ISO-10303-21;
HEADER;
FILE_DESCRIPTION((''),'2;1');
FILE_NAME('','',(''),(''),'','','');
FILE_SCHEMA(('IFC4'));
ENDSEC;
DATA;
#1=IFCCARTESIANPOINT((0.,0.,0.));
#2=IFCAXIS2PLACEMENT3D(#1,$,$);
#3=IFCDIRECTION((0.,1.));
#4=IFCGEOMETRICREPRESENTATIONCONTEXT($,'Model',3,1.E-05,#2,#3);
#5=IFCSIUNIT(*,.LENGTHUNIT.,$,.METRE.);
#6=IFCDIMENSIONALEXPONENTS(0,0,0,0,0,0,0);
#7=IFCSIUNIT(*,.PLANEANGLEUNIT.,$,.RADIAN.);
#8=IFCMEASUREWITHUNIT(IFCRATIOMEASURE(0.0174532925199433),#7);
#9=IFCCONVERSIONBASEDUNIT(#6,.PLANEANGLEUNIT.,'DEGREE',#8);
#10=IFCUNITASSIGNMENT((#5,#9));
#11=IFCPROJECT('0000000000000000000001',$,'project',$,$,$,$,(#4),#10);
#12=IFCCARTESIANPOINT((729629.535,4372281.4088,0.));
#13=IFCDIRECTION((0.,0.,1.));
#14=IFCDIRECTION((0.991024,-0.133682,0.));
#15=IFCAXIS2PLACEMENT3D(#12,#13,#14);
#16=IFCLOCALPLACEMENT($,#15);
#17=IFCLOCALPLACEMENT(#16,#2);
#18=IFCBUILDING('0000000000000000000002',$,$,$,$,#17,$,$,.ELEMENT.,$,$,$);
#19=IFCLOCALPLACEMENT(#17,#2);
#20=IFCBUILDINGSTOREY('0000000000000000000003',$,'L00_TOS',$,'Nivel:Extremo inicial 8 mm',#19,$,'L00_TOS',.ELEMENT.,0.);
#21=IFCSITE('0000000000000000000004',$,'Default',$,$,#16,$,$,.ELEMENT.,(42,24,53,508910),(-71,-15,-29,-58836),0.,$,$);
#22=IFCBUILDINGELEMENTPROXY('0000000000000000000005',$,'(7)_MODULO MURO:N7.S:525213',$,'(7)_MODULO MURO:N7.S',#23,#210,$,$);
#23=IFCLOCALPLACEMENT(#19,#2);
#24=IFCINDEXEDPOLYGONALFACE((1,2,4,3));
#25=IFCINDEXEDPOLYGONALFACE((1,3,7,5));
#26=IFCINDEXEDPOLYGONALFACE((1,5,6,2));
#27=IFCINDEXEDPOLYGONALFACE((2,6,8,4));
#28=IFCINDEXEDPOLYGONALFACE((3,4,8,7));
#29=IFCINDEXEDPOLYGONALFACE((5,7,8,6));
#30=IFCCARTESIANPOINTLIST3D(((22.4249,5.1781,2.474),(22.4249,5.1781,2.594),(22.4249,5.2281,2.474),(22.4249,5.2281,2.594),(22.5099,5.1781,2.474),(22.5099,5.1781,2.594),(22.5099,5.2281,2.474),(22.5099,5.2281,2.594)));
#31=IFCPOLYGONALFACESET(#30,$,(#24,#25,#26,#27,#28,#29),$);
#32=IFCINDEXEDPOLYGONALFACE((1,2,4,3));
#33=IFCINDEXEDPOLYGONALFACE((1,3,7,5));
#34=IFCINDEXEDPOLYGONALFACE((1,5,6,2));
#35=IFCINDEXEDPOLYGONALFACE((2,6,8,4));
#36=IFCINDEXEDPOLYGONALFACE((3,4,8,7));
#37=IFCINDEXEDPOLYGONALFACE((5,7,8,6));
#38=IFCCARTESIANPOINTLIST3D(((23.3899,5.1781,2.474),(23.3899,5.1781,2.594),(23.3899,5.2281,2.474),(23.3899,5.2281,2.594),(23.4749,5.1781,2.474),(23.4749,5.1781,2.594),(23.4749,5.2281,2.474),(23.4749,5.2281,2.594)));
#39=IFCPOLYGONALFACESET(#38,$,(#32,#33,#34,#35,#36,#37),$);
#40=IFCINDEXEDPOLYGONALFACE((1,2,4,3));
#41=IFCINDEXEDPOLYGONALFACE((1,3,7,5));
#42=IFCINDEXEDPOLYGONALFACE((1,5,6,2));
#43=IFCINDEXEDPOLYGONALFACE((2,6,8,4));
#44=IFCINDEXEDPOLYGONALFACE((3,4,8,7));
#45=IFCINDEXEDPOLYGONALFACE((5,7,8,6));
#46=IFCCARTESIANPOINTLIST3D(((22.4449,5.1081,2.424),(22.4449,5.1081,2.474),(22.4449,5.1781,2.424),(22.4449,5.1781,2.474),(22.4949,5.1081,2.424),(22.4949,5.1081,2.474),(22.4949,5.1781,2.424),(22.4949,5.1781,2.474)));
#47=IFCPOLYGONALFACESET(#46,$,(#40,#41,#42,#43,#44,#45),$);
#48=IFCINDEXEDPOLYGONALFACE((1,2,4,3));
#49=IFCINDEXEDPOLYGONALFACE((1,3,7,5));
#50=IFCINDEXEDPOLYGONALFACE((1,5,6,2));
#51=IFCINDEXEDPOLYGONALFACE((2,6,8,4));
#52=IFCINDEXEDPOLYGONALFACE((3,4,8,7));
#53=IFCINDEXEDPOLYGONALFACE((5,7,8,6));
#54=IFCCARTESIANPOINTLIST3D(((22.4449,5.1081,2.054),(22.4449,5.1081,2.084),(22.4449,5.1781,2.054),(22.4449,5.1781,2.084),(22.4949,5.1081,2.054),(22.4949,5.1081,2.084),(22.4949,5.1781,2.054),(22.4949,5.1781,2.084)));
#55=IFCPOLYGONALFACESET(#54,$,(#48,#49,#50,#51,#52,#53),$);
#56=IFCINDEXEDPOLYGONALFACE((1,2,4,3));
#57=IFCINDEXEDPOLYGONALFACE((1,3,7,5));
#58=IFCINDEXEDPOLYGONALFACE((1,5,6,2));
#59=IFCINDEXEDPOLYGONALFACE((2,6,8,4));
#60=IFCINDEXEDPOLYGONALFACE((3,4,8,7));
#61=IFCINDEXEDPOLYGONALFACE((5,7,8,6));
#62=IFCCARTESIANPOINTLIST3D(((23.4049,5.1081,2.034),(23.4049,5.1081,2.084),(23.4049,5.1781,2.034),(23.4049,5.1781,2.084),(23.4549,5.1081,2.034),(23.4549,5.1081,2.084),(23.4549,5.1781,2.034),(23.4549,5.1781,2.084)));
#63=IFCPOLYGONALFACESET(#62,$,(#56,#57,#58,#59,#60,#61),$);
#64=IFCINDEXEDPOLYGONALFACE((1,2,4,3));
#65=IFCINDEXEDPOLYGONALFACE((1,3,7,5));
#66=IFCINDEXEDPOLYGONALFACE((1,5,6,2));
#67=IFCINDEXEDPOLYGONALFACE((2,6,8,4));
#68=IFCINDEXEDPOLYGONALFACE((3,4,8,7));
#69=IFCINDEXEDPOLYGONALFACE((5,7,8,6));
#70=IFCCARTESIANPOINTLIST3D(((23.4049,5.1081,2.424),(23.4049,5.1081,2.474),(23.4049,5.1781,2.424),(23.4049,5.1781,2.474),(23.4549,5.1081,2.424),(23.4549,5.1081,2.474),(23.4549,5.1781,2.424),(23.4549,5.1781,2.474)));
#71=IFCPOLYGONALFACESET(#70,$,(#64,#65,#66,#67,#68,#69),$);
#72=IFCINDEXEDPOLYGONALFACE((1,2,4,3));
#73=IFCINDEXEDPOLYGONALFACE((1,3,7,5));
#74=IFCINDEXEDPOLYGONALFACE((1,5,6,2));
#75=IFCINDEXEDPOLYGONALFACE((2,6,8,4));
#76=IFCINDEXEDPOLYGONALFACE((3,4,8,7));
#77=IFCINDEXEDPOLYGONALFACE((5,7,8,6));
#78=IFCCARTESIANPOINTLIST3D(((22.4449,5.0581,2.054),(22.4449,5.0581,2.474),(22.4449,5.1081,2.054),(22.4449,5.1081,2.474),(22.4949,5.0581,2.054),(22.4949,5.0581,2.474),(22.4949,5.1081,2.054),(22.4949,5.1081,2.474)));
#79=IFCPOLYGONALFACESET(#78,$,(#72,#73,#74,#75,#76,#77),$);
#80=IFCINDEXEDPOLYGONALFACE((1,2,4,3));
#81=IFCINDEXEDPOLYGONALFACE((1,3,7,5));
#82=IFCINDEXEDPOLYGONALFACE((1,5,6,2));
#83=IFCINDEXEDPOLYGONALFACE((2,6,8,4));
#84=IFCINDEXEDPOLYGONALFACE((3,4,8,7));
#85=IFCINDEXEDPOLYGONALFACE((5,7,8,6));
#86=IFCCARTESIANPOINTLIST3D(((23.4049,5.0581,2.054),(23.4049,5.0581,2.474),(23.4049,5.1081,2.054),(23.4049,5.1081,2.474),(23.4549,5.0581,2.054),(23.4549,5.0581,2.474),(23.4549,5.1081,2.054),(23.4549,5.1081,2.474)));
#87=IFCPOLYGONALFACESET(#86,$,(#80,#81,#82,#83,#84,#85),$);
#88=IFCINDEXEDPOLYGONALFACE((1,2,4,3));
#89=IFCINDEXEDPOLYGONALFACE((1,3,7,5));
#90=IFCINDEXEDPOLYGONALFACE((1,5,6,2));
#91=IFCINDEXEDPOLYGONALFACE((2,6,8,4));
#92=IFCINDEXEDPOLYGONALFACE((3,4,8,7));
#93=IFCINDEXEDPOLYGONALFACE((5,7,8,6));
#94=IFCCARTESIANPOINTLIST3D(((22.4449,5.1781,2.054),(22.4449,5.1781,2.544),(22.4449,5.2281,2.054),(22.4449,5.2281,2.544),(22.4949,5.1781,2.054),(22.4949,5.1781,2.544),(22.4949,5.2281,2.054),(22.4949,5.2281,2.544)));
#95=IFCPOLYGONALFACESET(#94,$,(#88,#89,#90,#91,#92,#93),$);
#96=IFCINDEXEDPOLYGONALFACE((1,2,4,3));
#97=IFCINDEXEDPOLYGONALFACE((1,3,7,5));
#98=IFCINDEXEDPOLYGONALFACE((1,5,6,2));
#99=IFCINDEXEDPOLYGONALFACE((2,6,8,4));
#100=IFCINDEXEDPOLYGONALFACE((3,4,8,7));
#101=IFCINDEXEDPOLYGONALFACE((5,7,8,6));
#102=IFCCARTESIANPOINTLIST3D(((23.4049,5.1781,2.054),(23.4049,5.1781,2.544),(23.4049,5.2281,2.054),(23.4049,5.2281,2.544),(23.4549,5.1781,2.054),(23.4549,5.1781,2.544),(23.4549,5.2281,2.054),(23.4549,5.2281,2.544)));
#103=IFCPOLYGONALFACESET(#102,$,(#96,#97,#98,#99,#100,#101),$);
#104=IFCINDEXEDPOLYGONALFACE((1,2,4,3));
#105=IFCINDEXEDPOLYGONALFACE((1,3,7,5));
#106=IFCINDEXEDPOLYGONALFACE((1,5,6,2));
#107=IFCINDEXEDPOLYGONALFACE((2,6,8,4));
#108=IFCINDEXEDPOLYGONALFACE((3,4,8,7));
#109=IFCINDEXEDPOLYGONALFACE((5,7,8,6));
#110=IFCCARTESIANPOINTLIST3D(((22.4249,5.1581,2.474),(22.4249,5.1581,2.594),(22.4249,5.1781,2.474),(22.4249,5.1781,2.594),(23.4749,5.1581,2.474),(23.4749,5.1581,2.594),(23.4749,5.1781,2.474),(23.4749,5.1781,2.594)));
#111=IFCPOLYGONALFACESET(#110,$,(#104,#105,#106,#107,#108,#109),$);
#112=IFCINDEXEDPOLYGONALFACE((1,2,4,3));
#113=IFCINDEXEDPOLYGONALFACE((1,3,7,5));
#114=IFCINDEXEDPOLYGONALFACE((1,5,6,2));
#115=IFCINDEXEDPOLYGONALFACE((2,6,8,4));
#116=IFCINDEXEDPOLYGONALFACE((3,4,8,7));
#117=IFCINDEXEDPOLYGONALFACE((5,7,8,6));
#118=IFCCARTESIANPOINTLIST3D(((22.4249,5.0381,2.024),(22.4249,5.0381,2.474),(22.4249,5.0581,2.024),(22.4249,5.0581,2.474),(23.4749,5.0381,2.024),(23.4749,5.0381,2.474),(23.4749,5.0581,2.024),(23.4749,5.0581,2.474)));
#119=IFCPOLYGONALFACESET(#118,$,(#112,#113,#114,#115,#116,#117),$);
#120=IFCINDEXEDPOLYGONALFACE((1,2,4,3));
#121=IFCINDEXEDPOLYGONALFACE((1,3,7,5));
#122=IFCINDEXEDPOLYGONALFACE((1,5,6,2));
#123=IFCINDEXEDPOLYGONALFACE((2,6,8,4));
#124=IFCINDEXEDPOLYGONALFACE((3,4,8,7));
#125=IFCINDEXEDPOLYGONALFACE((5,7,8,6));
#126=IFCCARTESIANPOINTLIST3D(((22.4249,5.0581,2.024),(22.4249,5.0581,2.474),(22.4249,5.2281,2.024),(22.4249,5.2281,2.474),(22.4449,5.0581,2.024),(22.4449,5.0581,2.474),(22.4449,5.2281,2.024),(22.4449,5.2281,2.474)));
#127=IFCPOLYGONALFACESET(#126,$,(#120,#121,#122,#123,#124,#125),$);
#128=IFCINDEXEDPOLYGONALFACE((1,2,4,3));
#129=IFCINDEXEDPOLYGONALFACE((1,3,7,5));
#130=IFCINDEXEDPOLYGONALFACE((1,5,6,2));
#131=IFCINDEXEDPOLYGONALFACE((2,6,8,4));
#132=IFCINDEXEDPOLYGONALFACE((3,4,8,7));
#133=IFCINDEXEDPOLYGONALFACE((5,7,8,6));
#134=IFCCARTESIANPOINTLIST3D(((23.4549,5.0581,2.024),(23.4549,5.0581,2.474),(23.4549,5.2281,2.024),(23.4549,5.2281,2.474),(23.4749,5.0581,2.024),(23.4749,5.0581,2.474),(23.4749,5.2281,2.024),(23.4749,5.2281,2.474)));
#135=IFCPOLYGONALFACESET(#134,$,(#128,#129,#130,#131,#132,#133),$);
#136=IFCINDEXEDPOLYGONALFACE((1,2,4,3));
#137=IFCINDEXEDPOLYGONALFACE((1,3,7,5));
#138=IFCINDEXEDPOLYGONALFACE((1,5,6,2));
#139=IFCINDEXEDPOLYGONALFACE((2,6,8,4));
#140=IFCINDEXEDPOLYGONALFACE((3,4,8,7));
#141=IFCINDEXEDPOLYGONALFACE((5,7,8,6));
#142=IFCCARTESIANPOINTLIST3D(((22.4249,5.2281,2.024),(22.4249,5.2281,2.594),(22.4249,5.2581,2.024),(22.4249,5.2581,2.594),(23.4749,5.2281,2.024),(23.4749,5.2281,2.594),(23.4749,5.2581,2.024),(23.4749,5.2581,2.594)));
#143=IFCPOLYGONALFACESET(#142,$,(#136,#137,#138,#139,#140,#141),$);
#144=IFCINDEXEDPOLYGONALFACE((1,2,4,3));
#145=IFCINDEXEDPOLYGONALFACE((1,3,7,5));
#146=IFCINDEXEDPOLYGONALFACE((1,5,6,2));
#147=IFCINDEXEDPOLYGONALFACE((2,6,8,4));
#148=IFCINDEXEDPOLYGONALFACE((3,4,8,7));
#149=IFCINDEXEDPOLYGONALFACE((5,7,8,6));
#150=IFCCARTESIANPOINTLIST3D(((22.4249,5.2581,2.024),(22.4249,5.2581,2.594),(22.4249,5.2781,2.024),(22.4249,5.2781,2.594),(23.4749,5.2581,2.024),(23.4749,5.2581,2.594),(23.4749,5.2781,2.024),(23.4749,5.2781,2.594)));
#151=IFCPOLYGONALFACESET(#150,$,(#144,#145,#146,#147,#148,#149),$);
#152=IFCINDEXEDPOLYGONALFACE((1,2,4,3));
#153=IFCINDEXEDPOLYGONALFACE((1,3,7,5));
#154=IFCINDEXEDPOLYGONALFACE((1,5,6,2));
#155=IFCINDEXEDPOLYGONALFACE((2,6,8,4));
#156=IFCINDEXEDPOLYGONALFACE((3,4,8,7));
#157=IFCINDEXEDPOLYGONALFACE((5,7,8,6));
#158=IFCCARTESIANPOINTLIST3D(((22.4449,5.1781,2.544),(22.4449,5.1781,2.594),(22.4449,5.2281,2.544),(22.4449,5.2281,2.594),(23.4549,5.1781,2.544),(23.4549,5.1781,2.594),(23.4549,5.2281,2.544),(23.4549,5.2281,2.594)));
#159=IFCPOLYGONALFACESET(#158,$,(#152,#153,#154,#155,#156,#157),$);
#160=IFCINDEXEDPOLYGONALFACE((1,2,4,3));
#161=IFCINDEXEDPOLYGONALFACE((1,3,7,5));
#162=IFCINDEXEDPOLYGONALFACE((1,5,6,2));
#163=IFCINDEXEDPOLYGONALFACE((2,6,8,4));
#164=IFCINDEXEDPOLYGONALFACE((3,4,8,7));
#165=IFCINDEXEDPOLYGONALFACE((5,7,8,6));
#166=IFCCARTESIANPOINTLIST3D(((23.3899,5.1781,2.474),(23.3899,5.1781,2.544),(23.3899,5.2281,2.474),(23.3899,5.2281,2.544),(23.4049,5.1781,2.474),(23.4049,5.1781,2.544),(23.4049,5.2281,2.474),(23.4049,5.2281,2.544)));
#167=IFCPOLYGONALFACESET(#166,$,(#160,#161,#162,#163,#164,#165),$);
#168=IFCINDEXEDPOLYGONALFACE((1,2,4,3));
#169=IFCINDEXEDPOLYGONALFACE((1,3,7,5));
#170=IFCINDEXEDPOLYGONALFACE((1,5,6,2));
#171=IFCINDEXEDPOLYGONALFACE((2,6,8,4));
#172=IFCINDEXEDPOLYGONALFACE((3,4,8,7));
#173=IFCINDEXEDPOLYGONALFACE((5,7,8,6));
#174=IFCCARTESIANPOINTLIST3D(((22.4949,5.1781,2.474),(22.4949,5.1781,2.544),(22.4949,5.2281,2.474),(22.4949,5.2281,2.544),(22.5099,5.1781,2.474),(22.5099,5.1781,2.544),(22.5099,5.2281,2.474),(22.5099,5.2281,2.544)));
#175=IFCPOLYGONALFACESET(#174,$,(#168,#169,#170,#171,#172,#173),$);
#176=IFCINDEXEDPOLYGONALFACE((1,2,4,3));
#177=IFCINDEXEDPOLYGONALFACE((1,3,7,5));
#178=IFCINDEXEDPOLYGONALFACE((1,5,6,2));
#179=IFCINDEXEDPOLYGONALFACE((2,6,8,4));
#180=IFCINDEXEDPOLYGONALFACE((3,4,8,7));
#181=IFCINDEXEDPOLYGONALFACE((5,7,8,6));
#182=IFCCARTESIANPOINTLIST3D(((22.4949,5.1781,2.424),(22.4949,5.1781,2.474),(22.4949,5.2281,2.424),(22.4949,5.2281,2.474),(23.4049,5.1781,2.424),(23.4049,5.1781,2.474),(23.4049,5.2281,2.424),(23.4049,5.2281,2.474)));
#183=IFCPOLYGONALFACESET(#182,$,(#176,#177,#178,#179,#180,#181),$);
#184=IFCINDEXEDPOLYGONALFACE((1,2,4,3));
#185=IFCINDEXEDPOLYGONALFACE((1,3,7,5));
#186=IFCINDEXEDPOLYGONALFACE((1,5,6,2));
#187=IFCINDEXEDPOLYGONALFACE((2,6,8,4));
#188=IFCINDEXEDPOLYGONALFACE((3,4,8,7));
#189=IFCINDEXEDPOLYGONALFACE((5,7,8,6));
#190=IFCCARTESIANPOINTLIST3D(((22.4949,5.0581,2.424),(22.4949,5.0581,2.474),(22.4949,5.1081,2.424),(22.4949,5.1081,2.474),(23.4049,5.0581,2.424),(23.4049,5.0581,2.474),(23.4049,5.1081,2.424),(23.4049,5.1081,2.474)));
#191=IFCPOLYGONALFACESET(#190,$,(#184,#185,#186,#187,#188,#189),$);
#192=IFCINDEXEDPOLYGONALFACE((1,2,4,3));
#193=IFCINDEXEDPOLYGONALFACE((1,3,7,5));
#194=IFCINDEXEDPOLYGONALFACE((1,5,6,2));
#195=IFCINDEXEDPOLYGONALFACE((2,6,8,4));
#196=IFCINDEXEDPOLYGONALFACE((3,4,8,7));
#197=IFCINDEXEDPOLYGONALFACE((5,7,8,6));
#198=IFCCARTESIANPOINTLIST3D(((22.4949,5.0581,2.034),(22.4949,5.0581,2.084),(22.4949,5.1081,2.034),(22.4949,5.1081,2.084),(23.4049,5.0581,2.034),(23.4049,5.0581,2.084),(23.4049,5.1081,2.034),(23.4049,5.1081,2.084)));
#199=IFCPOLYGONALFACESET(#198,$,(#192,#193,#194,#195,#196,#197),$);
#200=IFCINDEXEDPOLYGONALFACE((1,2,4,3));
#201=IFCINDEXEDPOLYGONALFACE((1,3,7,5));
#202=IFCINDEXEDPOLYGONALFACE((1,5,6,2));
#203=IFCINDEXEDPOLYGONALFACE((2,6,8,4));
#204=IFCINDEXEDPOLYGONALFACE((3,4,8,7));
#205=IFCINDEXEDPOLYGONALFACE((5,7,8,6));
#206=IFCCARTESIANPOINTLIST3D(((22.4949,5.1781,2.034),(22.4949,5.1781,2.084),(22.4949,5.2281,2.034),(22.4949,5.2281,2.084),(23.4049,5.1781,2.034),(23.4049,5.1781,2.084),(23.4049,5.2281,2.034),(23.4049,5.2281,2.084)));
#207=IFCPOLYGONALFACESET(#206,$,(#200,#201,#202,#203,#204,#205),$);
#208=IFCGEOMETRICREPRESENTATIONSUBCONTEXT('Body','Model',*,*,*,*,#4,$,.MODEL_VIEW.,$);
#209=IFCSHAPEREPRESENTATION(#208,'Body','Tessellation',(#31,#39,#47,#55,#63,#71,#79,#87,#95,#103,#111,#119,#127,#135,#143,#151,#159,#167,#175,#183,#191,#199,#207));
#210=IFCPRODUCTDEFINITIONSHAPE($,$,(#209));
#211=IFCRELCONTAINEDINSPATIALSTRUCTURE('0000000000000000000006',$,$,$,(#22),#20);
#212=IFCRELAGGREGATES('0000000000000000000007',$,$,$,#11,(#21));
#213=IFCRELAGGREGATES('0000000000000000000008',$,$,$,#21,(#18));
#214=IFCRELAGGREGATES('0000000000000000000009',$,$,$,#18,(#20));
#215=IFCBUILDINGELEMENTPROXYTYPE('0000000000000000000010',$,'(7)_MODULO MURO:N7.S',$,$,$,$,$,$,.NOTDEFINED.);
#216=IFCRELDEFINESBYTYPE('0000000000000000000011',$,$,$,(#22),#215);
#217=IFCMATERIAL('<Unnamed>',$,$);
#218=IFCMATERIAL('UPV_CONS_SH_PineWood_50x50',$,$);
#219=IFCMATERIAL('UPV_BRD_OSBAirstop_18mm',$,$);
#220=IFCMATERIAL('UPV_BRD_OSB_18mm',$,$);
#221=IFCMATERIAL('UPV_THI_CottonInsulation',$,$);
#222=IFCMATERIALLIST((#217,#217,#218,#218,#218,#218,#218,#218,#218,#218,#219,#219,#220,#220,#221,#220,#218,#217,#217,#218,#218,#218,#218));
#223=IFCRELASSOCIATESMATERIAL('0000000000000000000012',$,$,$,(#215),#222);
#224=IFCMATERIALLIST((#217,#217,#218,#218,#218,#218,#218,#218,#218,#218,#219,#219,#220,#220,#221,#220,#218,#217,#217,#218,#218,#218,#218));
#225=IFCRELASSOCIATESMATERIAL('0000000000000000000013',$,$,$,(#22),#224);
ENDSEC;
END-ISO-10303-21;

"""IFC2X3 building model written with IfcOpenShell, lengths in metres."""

from ifc_helpers import new_model, entity, si_unit, converted_unit, direction, frame, frame_2d, origin, origin_2d_with_axis, place, context, subcontext, project, spatial, rectangle, extrude, source, transform, mapped, material, material_list, type_object, type_shapes, element, save


model = new_model("IFC2X3")

# Units and contexts
model_context = context("Model", 3, precision=1e-05, world=origin(), true_north=direction((0.0, 1.0)))
body_context = subcontext(model_context, "Body", "Model", "MODEL_VIEW")
ifc_project = project(units=[si_unit("LENGTHUNIT", "METRE"), converted_unit("PLANEANGLEUNIT", "DEGREE", entity("IfcRatioMeasure", 0.0174532925199433), si_unit("PLANEANGLEUNIT", "RADIAN"), dimensions=[0, 0, 0, 0, 0, 0, 0])], contexts=[model_context])

# Site, building, storey
site_placement = place(None, frame((729629.535, 4372281.4088, 0.0), z_axis=(0.0, 0.0, 1.0), x_axis=(0.991024, -0.133682, 0.0)))
site = spatial("IfcSite", under=ifc_project, at=site_placement, Name="Default", CompositionType="ELEMENT", RefLatitude=(42, 24, 53, 508910), RefLongitude=(-71, -15, -29, -58836), RefElevation=0.0)
building_placement = place(site_placement, origin())
building = spatial("IfcBuilding", under=site, at=building_placement, CompositionType="ELEMENT")
storey_placement = place(building_placement, origin())
storey = spatial("IfcBuildingStorey", under=building, at=storey_placement, Name="L00_TOS", ObjectType="Nivel:Extremo inicial 8 mm", LongName="L00_TOS", CompositionType="ELEMENT", Elevation=0.0)

# Building element proxy
ifc_material_1 = material(Name="UPV_BRD_OSBAirstop_18mm")
ifc_material_2 = material(Name="UPV_BRD_OSB_18mm")
ifc_material_3 = material(Name="UPV_THI_CottonInsulation")
ifc_material_4 = material(Name="<Unnamed>")
ifc_material_5 = material(Name="UPV_CONS_SH_PineWood_50x50")
ifc_material_list_1 = material_list([ifc_material_4, ifc_material_4, ifc_material_5, ifc_material_5, ifc_material_5, ifc_material_5, ifc_material_5, ifc_material_5, ifc_material_5, ifc_material_5, ifc_material_1, ifc_material_1, ifc_material_2, ifc_material_2, ifc_material_3, ifc_material_2, ifc_material_5, ifc_material_4, ifc_material_4, ifc_material_5, ifc_material_5, ifc_material_5, ifc_material_5])
ifc_material_list_2 = material_list([ifc_material_4, ifc_material_4, ifc_material_5, ifc_material_5, ifc_material_5, ifc_material_5, ifc_material_5, ifc_material_5, ifc_material_5, ifc_material_5, ifc_material_1, ifc_material_1, ifc_material_2, ifc_material_2, ifc_material_3, ifc_material_2, ifc_material_5, ifc_material_4, ifc_material_4, ifc_material_5, ifc_material_5, ifc_material_5, ifc_material_5])
building_element_proxy_type_1 = type_object("IfcBuildingElementProxyType", Name="(7)_MODULO MURO:N7.S", PredefinedType="NOTDEFINED", material=ifc_material_list_2)
shared_shape_1 = source(origin(), body_context, "Body", "SweptSolid", [
    extrude(rectangle(XDim=0.085, YDim=0.05, at=frame_2d((0.0, 0.0), x_axis=(1.0, 0.0))), frame((-0.4825, 0.025, 2.05), z_axis=(0.0, 0.0, 1.0), x_axis=(-1.0, 0.0, 0.0)), (0.0, 0.0, 1.0), 0.12),
    extrude(rectangle(XDim=0.085, YDim=0.05, at=frame_2d((0.0, 0.0), x_axis=(1.0, 0.0))), frame((0.4825, 0.025, 2.05), z_axis=(0.0, 0.0, 1.0), x_axis=(-1.0, 0.0, 0.0)), (0.0, 0.0, 1.0), 0.12),
    extrude(rectangle(XDim=0.07, YDim=0.05, at=frame_2d((0.0, 0.0), x_axis=(1.0, 0.0))), frame((-0.48, -0.035, 2.0), z_axis=(0.0, 0.0, 1.0), x_axis=(0.0, 1.0, 0.0)), (0.0, 0.0, 1.0), 0.05),
    extrude(rectangle(XDim=0.07, YDim=0.05, at=frame_2d((0.0, 0.0), x_axis=(1.0, 0.0))), frame((-0.48, -0.035, 1.63), z_axis=(0.0, 0.0, 1.0), x_axis=(0.0, 1.0, 0.0)), (0.0, 0.0, 1.0), 0.03),
    extrude(rectangle(XDim=0.07, YDim=0.05, at=frame_2d((0.0, 0.0), x_axis=(1.0, 0.0))), frame((0.48, -0.035, 1.61), z_axis=(0.0, 0.0, 1.0), x_axis=(0.0, 1.0, 0.0)), (0.0, 0.0, 1.0), 0.05),
    extrude(rectangle(XDim=0.07, YDim=0.05, at=frame_2d((0.0, 0.0), x_axis=(1.0, 0.0))), frame((0.48, -0.035, 2.0), z_axis=(0.0, 0.0, 1.0), x_axis=(0.0, 1.0, 0.0)), (0.0, 0.0, 1.0), 0.05),
    extrude(rectangle(XDim=0.05, YDim=0.05, at=frame_2d((0.0, 0.0), x_axis=(1.0, 0.0))), frame((-0.48, -0.095, 1.63), z_axis=(0.0, 0.0, 1.0), x_axis=(0.0, -1.0, 0.0)), (0.0, 0.0, 1.0), 0.42),
    extrude(rectangle(XDim=0.05, YDim=0.05, at=frame_2d((0.0, 0.0), x_axis=(1.0, 0.0))), frame((0.48, -0.095, 1.63), z_axis=(0.0, 0.0, 1.0), x_axis=(0.0, -1.0, 0.0)), (0.0, 0.0, 1.0), 0.42),
    extrude(rectangle(XDim=0.05, YDim=0.05, at=origin_2d_with_axis()), frame((-0.48, 0.025, 1.63), z_axis=(0.0, 0.0, 1.0), x_axis=(0.0, -1.0, 0.0)), (0.0, 0.0, 1.0), 0.49),
    extrude(rectangle(XDim=0.05, YDim=0.05, at=origin_2d_with_axis()), frame((0.48, 0.025, 1.63), z_axis=(0.0, 0.0, 1.0), x_axis=(0.0, -1.0, 0.0)), (0.0, 0.0, 1.0), 0.49),
    extrude(rectangle(XDim=1.05, YDim=0.02, at=origin_2d_with_axis()), frame((0.0, -0.01, 2.05), z_axis=(0.0, 0.0, 1.0), x_axis=(-1.0, 0.0, 0.0)), (0.0, 0.0, 1.0), 0.12),
    extrude(rectangle(XDim=1.05, YDim=0.02, at=origin_2d_with_axis()), frame((0.0, -0.13, 1.6)), (0.0, 0.0, 1.0), 0.45),
    extrude(rectangle(XDim=0.17, YDim=0.02, at=origin_2d_with_axis()), frame((-0.515, -0.035, 1.6), z_axis=(0.0, 0.0, 1.0), x_axis=(0.0, -1.0, 0.0)), (0.0, 0.0, 1.0), 0.45),
    extrude(rectangle(XDim=0.17, YDim=0.02, at=frame_2d((0.0, 0.0), x_axis=(1.0, 0.0))), frame((0.515, -0.035, 1.6), z_axis=(0.0, 0.0, 1.0), x_axis=(0.0, -1.0, 0.0)), (0.0, 0.0, 1.0), 0.45),
    extrude(rectangle(XDim=0.03, YDim=1.05, at=origin_2d_with_axis()), frame((0.0, 0.065, 1.6), z_axis=(0.0, 0.0, 1.0), x_axis=(0.0, 1.0, 0.0)), (0.0, 0.0, 1.0), 0.57),
    extrude(rectangle(XDim=0.02, YDim=1.05, at=origin_2d_with_axis()), frame((0.0, 0.09, 1.6), z_axis=(0.0, 0.0, 1.0), x_axis=(0.0, 1.0, 0.0)), (0.0, 0.0, 1.0), 0.57),
    extrude(rectangle(XDim=1.01, YDim=0.05, at=frame_2d((0.0, 0.0), x_axis=(1.0, 0.0))), frame((0.0, 0.025, 2.12), z_axis=(0.0, 0.0, 1.0), x_axis=(-1.0, 0.0, 0.0)), (0.0, 0.0, 1.0), 0.05),
    extrude(rectangle(XDim=0.015, YDim=0.05, at=frame_2d((0.0, 0.0), x_axis=(1.0, 0.0))), frame((0.4475, 0.025, 2.05), z_axis=(0.0, 0.0, 1.0), x_axis=(-1.0, 0.0, 0.0)), (0.0, 0.0, 1.0), 0.07),
    extrude(rectangle(XDim=0.05, YDim=0.015, at=frame_2d((0.0, 0.0), x_axis=(1.0, 0.0))), frame((-0.4475, 0.025, 2.05), z_axis=(0.0, 0.0, 1.0), x_axis=(0.0, 1.0, 0.0)), (0.0, 0.0, 1.0), 0.07),
    extrude(rectangle(XDim=0.91, YDim=0.05, at=origin_2d_with_axis()), frame((0.0, 0.025, 2.0), z_axis=(0.0, 0.0, 1.0), x_axis=(-1.0, 0.0, 0.0)), (0.0, 0.0, 1.0), 0.05),
    extrude(rectangle(XDim=0.91, YDim=0.05, at=frame_2d((0.0, 0.0), x_axis=(1.0, 0.0))), frame((0.0, -0.095, 2.0), z_axis=(0.0, 0.0, 1.0), x_axis=(-1.0, 0.0, 0.0)), (0.0, 0.0, 1.0), 0.05),
    extrude(rectangle(XDim=0.91, YDim=0.05, at=frame_2d((0.0, 0.0), x_axis=(1.0, 0.0))), frame((0.0, -0.095, 1.61), z_axis=(0.0, 0.0, 1.0), x_axis=(-1.0, 0.0, 0.0)), (0.0, 0.0, 1.0), 0.05),
    extrude(rectangle(XDim=0.91, YDim=0.05, at=origin_2d_with_axis()), frame((0.0, 0.025, 1.61), z_axis=(0.0, 0.0, 1.0), x_axis=(-1.0, 0.0, 0.0)), (0.0, 0.0, 1.0), 0.05),
])
type_shapes(building_element_proxy_type_1, [shared_shape_1])
proxy_1_placement = place(storey_placement, frame((22.9499, 5.1781, 0.424)))
element("IfcBuildingElementProxy", 1, at=proxy_1_placement, inside=storey, type_object=building_element_proxy_type_1, material=ifc_material_list_1, Name="(7)_MODULO MURO:N7.S:525213", ObjectType="(7)_MODULO MURO:N7.S", context=body_context, shape_type="MappedRepresentation", body=[
    mapped(shared_shape_1, transform((0.0, 0.0, 0.0), scale=1.0)),
])

save(model, "model.ifc")
